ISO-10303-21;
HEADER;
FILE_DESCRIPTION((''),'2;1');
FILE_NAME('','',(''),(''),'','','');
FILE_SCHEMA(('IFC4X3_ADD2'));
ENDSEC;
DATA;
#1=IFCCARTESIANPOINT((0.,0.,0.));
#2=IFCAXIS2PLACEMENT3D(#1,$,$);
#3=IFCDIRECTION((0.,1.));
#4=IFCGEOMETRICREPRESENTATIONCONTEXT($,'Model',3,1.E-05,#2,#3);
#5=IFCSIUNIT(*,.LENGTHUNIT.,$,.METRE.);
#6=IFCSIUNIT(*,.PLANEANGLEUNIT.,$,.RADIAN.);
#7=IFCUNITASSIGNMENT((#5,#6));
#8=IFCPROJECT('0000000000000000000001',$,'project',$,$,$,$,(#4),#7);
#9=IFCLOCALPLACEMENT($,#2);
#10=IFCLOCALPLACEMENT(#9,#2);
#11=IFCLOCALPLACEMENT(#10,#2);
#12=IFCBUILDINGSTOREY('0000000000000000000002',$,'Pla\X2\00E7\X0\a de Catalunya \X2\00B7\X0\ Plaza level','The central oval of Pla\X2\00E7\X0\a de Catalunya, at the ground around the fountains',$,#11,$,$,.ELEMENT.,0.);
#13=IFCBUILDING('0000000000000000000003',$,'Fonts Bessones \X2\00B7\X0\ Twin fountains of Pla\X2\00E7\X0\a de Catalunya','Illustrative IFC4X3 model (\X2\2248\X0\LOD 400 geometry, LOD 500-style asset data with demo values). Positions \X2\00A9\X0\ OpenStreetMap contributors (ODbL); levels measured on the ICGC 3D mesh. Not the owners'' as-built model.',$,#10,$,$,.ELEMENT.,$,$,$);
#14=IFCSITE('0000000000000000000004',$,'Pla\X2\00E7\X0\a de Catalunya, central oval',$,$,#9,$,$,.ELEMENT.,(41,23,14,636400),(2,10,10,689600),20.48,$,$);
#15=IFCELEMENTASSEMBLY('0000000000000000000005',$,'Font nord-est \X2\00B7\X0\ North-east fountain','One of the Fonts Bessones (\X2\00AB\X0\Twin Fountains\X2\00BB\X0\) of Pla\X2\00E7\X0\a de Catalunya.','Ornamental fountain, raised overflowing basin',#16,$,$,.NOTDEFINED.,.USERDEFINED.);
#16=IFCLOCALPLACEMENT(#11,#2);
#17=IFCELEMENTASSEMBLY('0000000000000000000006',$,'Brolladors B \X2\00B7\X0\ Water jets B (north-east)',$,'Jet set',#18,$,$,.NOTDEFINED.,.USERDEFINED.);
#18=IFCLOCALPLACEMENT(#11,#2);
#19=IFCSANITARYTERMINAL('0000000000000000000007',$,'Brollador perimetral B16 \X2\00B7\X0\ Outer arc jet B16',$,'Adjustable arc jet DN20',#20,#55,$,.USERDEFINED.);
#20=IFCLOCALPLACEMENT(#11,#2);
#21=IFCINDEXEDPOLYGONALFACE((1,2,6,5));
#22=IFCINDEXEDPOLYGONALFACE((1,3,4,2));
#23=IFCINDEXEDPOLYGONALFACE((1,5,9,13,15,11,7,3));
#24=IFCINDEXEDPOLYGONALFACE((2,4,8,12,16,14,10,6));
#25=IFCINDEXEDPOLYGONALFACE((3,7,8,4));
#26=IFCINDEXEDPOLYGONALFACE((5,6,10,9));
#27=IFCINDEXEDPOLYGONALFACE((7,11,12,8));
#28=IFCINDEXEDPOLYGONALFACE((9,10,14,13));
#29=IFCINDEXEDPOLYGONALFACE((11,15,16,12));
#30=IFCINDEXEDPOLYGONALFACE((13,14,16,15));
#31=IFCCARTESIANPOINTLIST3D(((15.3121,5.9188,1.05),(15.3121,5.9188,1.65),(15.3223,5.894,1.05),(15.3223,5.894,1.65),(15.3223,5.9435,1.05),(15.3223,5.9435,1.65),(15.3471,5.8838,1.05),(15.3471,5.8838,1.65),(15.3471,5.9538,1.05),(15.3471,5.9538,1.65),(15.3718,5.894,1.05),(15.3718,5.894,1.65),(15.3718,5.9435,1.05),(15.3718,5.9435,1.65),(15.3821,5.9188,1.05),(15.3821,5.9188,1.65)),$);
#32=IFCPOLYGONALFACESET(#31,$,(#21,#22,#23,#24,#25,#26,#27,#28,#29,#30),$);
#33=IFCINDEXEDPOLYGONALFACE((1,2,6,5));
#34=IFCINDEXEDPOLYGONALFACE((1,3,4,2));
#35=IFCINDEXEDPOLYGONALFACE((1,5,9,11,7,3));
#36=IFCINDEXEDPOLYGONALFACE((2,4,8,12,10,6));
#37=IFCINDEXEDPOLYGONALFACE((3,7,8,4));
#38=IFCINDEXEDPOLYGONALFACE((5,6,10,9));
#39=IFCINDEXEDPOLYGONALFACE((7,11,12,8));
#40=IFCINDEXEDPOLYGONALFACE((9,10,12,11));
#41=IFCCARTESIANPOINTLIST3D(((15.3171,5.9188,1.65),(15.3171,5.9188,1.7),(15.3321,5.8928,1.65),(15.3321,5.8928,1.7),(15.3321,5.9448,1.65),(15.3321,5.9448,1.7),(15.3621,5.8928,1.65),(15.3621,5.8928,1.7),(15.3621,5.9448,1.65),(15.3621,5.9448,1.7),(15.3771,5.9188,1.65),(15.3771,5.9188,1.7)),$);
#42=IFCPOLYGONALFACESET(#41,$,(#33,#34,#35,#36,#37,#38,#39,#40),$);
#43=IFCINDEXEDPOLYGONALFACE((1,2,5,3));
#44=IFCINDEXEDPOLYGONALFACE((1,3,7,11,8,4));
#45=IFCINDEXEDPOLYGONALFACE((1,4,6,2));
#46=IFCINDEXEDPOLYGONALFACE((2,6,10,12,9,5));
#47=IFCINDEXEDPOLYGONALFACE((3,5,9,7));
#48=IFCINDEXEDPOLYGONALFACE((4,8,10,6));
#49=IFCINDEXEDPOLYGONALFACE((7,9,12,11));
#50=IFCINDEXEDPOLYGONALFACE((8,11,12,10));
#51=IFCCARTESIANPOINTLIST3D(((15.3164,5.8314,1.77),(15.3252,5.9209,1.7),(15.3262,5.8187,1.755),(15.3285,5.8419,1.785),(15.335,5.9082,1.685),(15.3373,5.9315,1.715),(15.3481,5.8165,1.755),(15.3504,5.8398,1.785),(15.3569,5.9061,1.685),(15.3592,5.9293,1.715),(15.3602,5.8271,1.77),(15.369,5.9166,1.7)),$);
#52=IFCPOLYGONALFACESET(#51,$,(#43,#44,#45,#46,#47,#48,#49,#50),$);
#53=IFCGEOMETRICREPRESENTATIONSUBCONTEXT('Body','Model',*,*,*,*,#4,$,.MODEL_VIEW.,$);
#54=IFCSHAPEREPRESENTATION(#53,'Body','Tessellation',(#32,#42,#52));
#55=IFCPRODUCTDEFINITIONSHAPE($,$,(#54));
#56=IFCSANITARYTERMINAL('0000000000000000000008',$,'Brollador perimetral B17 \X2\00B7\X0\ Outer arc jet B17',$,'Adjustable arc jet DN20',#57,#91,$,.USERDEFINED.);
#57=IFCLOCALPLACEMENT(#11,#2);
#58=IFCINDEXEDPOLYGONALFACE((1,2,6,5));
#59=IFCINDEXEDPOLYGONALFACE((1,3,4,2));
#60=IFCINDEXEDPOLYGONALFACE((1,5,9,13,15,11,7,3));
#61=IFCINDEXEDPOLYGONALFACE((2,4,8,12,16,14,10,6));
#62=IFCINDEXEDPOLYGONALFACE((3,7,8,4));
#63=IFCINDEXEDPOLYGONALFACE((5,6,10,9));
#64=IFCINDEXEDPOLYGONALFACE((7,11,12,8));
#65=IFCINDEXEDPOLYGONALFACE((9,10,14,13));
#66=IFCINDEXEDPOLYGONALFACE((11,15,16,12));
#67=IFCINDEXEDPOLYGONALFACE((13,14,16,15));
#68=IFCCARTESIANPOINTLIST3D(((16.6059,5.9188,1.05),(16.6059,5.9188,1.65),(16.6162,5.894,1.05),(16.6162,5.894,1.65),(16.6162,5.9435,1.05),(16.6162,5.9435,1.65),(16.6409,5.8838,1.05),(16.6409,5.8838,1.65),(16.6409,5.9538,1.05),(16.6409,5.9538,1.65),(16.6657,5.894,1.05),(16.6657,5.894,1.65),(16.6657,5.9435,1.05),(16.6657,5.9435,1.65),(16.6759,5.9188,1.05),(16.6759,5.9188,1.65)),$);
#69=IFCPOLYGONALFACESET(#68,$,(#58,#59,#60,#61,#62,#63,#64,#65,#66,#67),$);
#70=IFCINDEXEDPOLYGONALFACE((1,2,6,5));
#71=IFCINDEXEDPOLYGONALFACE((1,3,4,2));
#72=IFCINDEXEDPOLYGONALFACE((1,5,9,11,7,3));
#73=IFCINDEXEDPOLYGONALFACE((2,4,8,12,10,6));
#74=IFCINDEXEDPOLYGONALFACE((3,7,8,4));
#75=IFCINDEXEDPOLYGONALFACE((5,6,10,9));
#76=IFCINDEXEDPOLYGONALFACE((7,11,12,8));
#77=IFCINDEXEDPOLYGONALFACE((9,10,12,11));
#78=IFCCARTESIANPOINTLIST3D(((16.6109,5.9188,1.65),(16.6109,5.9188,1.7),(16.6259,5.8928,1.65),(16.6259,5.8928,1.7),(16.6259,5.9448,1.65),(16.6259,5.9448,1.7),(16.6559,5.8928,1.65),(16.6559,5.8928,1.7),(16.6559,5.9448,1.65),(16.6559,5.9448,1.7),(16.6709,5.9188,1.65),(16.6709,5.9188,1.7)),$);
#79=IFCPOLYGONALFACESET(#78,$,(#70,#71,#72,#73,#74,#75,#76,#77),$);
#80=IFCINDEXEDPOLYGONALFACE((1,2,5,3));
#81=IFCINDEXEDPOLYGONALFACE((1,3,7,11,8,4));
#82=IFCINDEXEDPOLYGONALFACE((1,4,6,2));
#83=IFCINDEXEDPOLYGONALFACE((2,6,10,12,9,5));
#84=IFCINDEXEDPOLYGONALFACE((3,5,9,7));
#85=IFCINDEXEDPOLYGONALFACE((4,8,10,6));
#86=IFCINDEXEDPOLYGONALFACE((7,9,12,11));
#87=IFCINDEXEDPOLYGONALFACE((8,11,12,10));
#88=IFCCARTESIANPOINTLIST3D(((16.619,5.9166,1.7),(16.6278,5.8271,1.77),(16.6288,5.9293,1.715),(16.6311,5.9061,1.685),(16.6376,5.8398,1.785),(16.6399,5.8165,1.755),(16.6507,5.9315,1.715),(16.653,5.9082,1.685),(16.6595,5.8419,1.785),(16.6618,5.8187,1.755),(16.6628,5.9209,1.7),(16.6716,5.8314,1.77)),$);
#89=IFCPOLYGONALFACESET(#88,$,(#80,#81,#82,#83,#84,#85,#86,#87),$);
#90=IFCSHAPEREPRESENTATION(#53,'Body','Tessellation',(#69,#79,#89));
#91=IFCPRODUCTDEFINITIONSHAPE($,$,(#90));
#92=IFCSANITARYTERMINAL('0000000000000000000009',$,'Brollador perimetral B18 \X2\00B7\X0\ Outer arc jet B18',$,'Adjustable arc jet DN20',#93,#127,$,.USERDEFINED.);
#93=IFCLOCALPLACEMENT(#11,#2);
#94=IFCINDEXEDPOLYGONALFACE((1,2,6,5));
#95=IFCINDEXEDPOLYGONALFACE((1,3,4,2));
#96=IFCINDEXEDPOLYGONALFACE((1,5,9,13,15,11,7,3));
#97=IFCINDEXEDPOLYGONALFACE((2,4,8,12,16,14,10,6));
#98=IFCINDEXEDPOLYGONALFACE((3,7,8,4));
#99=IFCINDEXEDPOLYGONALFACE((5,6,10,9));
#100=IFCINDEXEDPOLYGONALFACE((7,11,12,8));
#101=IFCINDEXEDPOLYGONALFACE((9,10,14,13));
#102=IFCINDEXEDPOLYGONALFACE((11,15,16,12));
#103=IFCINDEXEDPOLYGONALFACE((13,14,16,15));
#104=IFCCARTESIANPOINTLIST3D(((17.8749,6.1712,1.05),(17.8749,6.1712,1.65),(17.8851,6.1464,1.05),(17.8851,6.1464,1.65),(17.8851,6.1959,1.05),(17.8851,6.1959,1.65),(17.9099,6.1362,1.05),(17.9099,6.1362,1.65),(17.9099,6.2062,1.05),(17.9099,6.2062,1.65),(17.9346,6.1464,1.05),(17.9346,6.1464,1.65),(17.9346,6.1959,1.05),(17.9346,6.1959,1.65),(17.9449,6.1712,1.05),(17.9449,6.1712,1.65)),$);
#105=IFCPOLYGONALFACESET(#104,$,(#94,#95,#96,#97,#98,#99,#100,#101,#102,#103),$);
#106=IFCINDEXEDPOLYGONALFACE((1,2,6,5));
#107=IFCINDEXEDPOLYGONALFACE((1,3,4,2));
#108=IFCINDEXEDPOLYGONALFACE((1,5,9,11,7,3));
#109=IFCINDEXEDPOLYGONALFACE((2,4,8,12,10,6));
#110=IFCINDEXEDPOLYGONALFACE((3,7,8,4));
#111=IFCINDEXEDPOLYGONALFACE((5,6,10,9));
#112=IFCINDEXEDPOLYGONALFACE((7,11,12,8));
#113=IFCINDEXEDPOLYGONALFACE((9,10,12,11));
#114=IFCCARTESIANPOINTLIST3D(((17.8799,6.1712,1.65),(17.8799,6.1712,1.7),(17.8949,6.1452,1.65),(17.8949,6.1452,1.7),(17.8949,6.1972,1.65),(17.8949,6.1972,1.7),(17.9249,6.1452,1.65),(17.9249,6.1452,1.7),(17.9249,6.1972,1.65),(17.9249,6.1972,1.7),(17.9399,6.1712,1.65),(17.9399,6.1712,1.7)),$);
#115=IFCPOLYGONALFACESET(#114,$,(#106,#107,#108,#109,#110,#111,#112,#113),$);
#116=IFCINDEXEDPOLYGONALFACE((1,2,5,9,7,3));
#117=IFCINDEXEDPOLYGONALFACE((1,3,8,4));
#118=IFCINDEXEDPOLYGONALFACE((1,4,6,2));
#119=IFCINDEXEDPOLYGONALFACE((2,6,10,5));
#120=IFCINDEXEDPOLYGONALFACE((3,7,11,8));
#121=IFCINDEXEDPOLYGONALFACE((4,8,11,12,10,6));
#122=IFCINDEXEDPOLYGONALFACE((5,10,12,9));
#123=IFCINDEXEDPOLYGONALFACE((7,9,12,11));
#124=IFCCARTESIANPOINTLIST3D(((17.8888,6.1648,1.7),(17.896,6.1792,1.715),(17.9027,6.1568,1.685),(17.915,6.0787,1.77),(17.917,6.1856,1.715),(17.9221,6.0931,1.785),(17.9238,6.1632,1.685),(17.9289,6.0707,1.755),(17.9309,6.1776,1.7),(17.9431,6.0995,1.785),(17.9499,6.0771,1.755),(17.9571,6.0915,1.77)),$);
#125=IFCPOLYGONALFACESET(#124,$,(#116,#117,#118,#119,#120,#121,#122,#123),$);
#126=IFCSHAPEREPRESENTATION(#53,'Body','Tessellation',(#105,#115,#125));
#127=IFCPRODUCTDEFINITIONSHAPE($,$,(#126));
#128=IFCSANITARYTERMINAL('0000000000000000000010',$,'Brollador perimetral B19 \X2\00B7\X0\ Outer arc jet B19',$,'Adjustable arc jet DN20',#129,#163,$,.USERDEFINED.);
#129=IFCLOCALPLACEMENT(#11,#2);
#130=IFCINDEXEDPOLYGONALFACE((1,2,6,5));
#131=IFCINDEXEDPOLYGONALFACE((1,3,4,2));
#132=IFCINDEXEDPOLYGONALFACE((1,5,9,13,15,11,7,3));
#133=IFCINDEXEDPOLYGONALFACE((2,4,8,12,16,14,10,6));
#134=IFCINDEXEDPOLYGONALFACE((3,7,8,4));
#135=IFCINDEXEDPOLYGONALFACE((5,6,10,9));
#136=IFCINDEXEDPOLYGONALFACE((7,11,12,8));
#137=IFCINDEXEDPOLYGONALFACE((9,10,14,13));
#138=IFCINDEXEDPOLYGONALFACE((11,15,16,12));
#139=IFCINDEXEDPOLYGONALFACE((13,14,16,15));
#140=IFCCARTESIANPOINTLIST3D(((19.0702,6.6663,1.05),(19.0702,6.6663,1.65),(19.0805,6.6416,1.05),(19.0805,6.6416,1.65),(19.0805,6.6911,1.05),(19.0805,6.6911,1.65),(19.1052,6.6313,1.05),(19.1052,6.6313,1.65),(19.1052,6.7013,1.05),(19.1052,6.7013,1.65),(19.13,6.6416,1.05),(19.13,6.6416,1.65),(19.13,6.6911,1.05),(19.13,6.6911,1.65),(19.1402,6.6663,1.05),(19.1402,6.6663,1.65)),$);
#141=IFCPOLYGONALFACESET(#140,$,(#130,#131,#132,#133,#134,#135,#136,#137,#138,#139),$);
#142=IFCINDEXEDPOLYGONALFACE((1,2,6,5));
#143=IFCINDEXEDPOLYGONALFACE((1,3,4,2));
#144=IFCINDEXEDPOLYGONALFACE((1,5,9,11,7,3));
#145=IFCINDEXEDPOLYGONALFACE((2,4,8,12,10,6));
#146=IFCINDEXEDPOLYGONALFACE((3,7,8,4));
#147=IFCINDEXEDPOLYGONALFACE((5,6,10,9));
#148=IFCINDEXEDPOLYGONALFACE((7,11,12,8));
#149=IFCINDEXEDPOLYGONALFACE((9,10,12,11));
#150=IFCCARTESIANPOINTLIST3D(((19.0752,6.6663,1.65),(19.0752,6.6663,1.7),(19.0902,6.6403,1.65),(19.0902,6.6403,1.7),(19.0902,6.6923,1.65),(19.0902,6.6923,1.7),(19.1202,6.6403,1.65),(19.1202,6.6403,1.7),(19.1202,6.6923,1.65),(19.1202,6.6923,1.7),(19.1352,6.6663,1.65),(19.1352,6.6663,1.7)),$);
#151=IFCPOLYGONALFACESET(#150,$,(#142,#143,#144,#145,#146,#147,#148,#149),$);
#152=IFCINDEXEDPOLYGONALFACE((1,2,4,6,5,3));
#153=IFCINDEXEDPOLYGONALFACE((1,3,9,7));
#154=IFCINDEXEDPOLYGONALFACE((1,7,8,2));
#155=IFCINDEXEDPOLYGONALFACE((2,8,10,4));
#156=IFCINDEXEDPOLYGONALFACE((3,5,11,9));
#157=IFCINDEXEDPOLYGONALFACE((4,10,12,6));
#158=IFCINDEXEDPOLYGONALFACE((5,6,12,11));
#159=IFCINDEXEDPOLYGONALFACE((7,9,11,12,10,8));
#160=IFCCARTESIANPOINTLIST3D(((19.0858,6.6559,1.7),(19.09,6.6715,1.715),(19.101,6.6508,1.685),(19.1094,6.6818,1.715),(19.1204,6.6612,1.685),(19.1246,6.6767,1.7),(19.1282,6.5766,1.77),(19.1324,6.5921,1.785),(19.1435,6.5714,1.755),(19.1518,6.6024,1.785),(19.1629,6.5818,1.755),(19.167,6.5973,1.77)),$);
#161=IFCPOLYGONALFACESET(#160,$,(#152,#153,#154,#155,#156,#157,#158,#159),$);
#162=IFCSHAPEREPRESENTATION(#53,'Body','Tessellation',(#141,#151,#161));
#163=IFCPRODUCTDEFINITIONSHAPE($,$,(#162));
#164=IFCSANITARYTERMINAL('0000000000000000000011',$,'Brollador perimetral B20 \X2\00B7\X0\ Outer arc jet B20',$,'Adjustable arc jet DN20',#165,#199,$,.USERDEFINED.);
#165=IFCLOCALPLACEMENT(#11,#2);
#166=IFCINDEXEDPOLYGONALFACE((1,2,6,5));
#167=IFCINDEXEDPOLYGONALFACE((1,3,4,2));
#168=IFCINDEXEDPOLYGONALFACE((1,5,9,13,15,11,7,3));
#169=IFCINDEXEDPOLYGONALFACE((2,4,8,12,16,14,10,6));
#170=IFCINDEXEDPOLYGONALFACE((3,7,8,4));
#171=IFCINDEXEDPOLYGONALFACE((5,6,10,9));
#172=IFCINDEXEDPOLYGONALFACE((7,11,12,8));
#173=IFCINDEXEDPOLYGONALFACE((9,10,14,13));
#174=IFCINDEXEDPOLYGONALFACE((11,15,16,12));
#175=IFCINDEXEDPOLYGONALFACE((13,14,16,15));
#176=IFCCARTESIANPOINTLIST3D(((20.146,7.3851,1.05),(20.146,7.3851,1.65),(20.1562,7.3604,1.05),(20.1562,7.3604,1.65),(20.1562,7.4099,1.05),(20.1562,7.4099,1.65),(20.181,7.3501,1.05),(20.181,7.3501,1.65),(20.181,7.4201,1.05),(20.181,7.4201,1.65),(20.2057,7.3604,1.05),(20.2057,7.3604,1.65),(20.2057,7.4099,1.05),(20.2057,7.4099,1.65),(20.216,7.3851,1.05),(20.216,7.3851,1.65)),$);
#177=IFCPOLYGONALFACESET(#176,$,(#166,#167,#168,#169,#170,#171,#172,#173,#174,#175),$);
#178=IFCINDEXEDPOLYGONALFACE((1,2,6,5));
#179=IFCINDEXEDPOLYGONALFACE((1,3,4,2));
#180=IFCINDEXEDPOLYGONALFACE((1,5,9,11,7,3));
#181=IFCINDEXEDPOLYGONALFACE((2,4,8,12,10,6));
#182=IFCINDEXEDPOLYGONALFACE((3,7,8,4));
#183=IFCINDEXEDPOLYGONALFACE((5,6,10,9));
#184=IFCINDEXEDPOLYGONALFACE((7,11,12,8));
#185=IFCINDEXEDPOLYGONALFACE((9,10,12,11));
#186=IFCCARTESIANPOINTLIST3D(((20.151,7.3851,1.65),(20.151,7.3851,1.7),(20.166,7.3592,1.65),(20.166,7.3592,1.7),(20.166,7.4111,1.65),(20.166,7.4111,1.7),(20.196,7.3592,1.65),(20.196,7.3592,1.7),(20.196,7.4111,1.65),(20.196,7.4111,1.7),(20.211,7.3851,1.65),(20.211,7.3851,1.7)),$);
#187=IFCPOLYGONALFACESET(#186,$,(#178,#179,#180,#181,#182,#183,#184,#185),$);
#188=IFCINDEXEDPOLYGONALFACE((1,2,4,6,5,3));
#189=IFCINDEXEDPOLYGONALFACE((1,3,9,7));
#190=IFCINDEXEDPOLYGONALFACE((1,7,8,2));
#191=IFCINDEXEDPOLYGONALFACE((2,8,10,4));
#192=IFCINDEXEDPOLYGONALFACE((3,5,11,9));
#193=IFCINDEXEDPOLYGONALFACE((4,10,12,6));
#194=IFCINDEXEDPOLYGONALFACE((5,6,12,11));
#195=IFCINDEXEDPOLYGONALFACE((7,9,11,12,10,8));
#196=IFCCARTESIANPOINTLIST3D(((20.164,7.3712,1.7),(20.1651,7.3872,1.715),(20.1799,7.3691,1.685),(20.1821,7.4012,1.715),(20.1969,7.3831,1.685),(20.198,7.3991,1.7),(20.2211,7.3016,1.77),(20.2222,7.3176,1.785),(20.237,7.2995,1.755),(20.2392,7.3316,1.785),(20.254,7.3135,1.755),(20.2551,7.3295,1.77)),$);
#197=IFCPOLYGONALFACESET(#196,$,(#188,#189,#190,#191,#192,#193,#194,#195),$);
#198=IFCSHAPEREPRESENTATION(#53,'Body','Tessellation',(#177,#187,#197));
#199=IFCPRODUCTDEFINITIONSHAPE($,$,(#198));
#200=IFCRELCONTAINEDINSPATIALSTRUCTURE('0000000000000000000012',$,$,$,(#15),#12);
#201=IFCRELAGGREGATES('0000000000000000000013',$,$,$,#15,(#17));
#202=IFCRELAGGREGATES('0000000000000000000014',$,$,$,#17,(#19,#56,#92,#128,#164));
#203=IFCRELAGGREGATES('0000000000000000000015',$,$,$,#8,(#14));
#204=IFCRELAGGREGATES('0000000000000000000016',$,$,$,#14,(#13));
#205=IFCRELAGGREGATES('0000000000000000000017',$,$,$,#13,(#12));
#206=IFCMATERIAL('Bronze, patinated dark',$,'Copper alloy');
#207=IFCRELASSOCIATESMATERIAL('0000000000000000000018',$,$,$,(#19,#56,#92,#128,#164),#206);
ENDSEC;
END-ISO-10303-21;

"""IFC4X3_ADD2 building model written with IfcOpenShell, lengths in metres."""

from ifc_helpers import new_model, si_unit, direction, frame, origin, place, context, subcontext, project, spatial, polyline, outline, extrude, material, element, aggregate, save


model = new_model("IFC4X3_ADD2")

# Units and contexts
model_context = context("Model", 3, precision=1e-05, world=origin(), true_north=direction((0.0, 1.0)))
body_context = subcontext(model_context, "Body", "Model", "MODEL_VIEW")
ifc_project = project(units=[si_unit("LENGTHUNIT", "METRE"), si_unit("PLANEANGLEUNIT", "RADIAN")], contexts=[model_context])

# Site, building, storey
site_placement = place(None, origin())
site = spatial("IfcSite", under=ifc_project, at=site_placement, Name="Plaça de Catalunya, central oval", CompositionType="ELEMENT", RefLatitude=(41, 23, 14, 636400), RefLongitude=(2, 10, 10, 689600), RefElevation=20.48)
building_placement = place(site_placement, origin())
building = spatial("IfcBuilding", under=site, at=building_placement, Name="Fonts Bessones · Twin fountains of Plaça de Catalunya", Description="Illustrative IFC4X3 model (≈LOD 400 geometry, LOD 500-style asset data with demo values). Positions © OpenStreetMap contributors (ODbL); levels measured on the ICGC 3D mesh. Not the owners' as-built model.", CompositionType="ELEMENT")
storey_placement = place(building_placement, origin())
storey = spatial("IfcBuildingStorey", under=building, at=storey_placement, Name="Plaça de Catalunya · Plaza level", Description="The central oval of Plaça de Catalunya, at the ground around the fountains", CompositionType="ELEMENT", Elevation=0.0)

# Element assemblies, sanitary terminals
assembly_1_placement = place(building_placement, origin())
assembly_1 = element("IfcElementAssembly", 1, at=assembly_1_placement, inside=storey, Name="Font nord-est · North-east fountain", Description="One of the Fonts Bessones («Twin Fountains») of Plaça de Catalunya.", ObjectType="Ornamental fountain, raised overflowing basin", AssemblyPlace="NOTDEFINED", PredefinedType="USERDEFINED")
assembly_2_placement = place(building_placement, origin())
assembly_2 = element("IfcElementAssembly", 2, at=assembly_2_placement, Name="Brolladors B · Water jets B (north-east)", ObjectType="Jet set", AssemblyPlace="NOTDEFINED", PredefinedType="USERDEFINED")
aggregate(assembly_1, [assembly_2])
ifc_material_1 = material(Name="Bronze, patinated dark", Category="Copper alloy")
sanitary_terminal_1_placement = place(building_placement, origin())
sanitary_terminal_1 = element("IfcSanitaryTerminal", 3, at=sanitary_terminal_1_placement, material=ifc_material_1, Name="Brollador perimetral B16 · Outer arc jet B16", ObjectType="Adjustable arc jet DN20", PredefinedType="USERDEFINED", context=body_context, shape_type="SweptSolid", body=[
    extrude(outline(polyline([(15.3821, 5.9188), (15.3718, 5.9435), (15.3471, 5.9538), (15.3223, 5.9435), (15.3121, 5.9188), (15.3223, 5.894), (15.3471, 5.8838), (15.3718, 5.894), (15.3821, 5.9188)])), frame((0.0, 0.0, 1.05)), (0.0, 0.0, 1.0), 0.6),
    extrude(outline(polyline([(15.3771, 5.9188), (15.3621, 5.9448), (15.3321, 5.9448), (15.3171, 5.9188), (15.3321, 5.8928), (15.3621, 5.8928), (15.3771, 5.9188)])), frame((0.0, 0.0, 1.65)), (0.0, 0.0, 1.0), 0.05),
    extrude(outline(polyline([(0.022, 0.0), (0.011, 0.0191), (-0.011, 0.0191), (-0.022, 0.0), (-0.011, -0.0191), (0.011, -0.0191), (0.022, 0.0)])), frame((15.3471, 5.9188, 1.7), z_axis=(-0.07737, -0.785551, 0.613941), x_axis=(-0.995185, 0.098017, 0.0)), (0.0, 0.0, 1.0), 0.114),
])
sanitary_terminal_2_placement = place(building_placement, origin())
sanitary_terminal_2 = element("IfcSanitaryTerminal", 4, at=sanitary_terminal_2_placement, material=ifc_material_1, Name="Brollador perimetral B17 · Outer arc jet B17", ObjectType="Adjustable arc jet DN20", PredefinedType="USERDEFINED", context=body_context, shape_type="SweptSolid", body=[
    extrude(outline(polyline([(16.6759, 5.9188), (16.6657, 5.9435), (16.6409, 5.9538), (16.6162, 5.9435), (16.6059, 5.9188), (16.6162, 5.894), (16.6409, 5.8838), (16.6657, 5.894), (16.6759, 5.9188)])), frame((0.0, 0.0, 1.05)), (0.0, 0.0, 1.0), 0.6),
    extrude(outline(polyline([(16.6709, 5.9188), (16.6559, 5.9448), (16.6259, 5.9448), (16.6109, 5.9188), (16.6259, 5.8928), (16.6559, 5.8928), (16.6709, 5.9188)])), frame((0.0, 0.0, 1.65)), (0.0, 0.0, 1.0), 0.05),
    extrude(outline(polyline([(0.022, 0.0), (0.011, 0.0191), (-0.011, 0.0191), (-0.022, 0.0), (-0.011, -0.0191), (0.011, -0.0191), (0.022, 0.0)])), frame((16.6409, 5.9188, 1.7), z_axis=(0.07737, -0.785551, 0.613941), x_axis=(-0.995185, -0.098017, 0.0)), (0.0, 0.0, 1.0), 0.114),
])
sanitary_terminal_3_placement = place(building_placement, origin())
sanitary_terminal_3 = element("IfcSanitaryTerminal", 5, at=sanitary_terminal_3_placement, material=ifc_material_1, Name="Brollador perimetral B18 · Outer arc jet B18", ObjectType="Adjustable arc jet DN20", PredefinedType="USERDEFINED", context=body_context, shape_type="SweptSolid", body=[
    extrude(outline(polyline([(17.9449, 6.1712), (17.9346, 6.1959), (17.9099, 6.2062), (17.8851, 6.1959), (17.8749, 6.1712), (17.8851, 6.1464), (17.9099, 6.1362), (17.9346, 6.1464), (17.9449, 6.1712)])), frame((0.0, 0.0, 1.05)), (0.0, 0.0, 1.0), 0.6),
    extrude(outline(polyline([(17.9399, 6.1712), (17.9249, 6.1972), (17.8949, 6.1972), (17.8799, 6.1712), (17.8949, 6.1452), (17.9249, 6.1452), (17.9399, 6.1712)])), frame((0.0, 0.0, 1.65)), (0.0, 0.0, 1.0), 0.05),
    extrude(outline(polyline([(0.022, 0.0), (0.011, 0.0191), (-0.011, 0.0191), (-0.022, 0.0), (-0.011, -0.0191), (0.011, -0.0191), (0.022, 0.0)])), frame((17.9099, 6.1712, 1.7), z_axis=(0.229137, -0.755363, 0.613941), x_axis=(-0.95694, -0.290285, 0.0)), (0.0, 0.0, 1.0), 0.114),
])
sanitary_terminal_4_placement = place(building_placement, origin())
sanitary_terminal_4 = element("IfcSanitaryTerminal", 6, at=sanitary_terminal_4_placement, material=ifc_material_1, Name="Brollador perimetral B19 · Outer arc jet B19", ObjectType="Adjustable arc jet DN20", PredefinedType="USERDEFINED", context=body_context, shape_type="SweptSolid", body=[
    extrude(outline(polyline([(19.1402, 6.6663), (19.13, 6.6911), (19.1052, 6.7013), (19.0805, 6.6911), (19.0702, 6.6663), (19.0805, 6.6416), (19.1052, 6.6313), (19.13, 6.6416), (19.1402, 6.6663)])), frame((0.0, 0.0, 1.05)), (0.0, 0.0, 1.0), 0.6),
    extrude(outline(polyline([(19.1352, 6.6663), (19.1202, 6.6923), (19.0902, 6.6923), (19.0752, 6.6663), (19.0902, 6.6403), (19.1202, 6.6403), (19.1352, 6.6663)])), frame((0.0, 0.0, 1.65)), (0.0, 0.0, 1.0), 0.05),
    extrude(outline(polyline([(0.022, 0.0), (0.011, 0.0191), (-0.011, 0.0191), (-0.022, 0.0), (-0.011, -0.0191), (0.011, -0.0191), (0.022, 0.0)])), frame((19.1052, 6.6663, 1.7), z_axis=(0.372098, -0.696147, 0.613941), x_axis=(-0.881921, -0.471397, 0.0)), (0.0, 0.0, 1.0), 0.114),
])
sanitary_terminal_5_placement = place(building_placement, origin())
sanitary_terminal_5 = element("IfcSanitaryTerminal", 7, at=sanitary_terminal_5_placement, material=ifc_material_1, Name="Brollador perimetral B20 · Outer arc jet B20", ObjectType="Adjustable arc jet DN20", PredefinedType="USERDEFINED", context=body_context, shape_type="SweptSolid", body=[
    extrude(outline(polyline([(20.216, 7.3851), (20.2057, 7.4099), (20.181, 7.4201), (20.1562, 7.4099), (20.146, 7.3851), (20.1562, 7.3604), (20.181, 7.3501), (20.2057, 7.3604), (20.216, 7.3851)])), frame((0.0, 0.0, 1.05)), (0.0, 0.0, 1.0), 0.6),
    extrude(outline(polyline([(20.211, 7.3851), (20.196, 7.4111), (20.166, 7.4111), (20.151, 7.3851), (20.166, 7.3592), (20.196, 7.3592), (20.211, 7.3851)])), frame((0.0, 0.0, 1.65)), (0.0, 0.0, 1.0), 0.05),
    extrude(outline(polyline([(0.022, 0.0), (0.011, 0.0191), (-0.011, 0.0191), (-0.022, 0.0), (-0.011, -0.0191), (0.011, -0.0191), (0.022, 0.0)])), frame((20.181, 7.3851, 1.7), z_axis=(0.50076, -0.610178, 0.613941), x_axis=(-0.77301, -0.634393, 0.0)), (0.0, 0.0, 1.0), 0.114),
])
aggregate(assembly_2, [sanitary_terminal_1, sanitary_terminal_2, sanitary_terminal_3, sanitary_terminal_4, sanitary_terminal_5])

save(model, "model.ifc")
